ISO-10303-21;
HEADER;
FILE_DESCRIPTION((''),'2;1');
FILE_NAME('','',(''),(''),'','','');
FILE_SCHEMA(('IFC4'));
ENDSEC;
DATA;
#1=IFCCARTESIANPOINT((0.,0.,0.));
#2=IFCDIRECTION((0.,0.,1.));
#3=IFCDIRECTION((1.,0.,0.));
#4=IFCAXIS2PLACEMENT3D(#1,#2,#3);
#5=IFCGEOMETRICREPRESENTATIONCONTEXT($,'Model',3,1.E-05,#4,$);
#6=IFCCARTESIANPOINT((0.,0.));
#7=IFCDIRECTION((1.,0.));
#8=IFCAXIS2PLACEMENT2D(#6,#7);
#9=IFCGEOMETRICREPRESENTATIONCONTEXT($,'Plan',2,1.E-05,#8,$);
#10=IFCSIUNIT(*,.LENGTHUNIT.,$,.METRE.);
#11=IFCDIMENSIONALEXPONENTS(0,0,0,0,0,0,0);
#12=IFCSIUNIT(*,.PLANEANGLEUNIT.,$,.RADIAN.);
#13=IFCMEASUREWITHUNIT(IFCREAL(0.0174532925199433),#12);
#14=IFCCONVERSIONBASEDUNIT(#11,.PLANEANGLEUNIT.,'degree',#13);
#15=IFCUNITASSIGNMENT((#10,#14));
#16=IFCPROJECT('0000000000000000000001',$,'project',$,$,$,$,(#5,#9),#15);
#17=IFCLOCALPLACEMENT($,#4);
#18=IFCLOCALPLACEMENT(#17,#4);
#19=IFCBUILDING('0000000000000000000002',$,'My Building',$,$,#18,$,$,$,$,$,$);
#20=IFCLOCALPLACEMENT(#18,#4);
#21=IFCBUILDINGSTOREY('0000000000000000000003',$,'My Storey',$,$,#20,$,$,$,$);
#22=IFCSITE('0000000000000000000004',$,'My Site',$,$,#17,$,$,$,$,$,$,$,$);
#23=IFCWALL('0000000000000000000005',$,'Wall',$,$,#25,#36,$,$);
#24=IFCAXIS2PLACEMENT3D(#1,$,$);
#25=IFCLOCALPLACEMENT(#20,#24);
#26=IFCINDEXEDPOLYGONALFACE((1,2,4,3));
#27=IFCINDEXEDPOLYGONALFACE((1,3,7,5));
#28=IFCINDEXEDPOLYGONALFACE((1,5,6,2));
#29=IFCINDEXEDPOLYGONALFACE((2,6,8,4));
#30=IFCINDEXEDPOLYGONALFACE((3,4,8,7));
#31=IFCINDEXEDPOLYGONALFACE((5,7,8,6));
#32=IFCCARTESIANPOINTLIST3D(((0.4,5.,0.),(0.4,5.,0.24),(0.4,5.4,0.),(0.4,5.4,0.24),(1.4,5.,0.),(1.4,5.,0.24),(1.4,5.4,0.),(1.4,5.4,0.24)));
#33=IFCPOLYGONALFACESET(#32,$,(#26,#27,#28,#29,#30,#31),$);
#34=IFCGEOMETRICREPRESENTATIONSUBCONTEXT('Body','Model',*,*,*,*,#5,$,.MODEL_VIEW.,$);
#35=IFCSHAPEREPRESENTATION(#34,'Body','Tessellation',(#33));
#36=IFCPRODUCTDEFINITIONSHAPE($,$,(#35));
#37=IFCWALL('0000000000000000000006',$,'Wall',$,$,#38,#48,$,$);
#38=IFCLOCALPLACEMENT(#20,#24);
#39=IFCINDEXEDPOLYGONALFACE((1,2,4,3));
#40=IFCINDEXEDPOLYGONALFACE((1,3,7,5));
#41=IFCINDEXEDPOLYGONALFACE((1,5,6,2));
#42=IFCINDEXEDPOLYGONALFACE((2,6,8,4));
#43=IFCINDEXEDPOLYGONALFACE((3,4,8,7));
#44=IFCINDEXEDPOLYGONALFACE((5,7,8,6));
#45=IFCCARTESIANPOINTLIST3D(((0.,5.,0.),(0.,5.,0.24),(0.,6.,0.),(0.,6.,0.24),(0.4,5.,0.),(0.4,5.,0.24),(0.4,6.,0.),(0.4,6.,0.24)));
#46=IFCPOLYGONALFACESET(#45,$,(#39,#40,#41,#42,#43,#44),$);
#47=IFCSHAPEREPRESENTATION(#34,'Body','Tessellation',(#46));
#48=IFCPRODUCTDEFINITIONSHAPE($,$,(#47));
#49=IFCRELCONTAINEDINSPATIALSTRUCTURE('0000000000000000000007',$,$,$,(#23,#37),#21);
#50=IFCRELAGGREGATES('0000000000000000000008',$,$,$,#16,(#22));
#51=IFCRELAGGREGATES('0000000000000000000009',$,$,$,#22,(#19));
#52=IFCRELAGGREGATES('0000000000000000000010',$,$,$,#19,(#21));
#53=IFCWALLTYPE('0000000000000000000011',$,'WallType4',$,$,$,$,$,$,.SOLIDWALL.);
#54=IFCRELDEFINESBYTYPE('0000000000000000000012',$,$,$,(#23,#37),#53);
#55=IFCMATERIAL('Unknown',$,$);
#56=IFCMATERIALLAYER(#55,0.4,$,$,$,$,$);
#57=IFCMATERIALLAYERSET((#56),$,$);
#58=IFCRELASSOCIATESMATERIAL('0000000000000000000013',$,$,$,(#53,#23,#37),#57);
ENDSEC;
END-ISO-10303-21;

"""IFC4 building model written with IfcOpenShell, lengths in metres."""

from ifc_helpers import new_model, entity, si_unit, converted_unit, frame, origin_with_axes, origin_2d_with_axis, place, context, subcontext, project, spatial, indexed_curve, outline, extrude, material, layer, layer_set, layer_usage, type_object, element, save


model = new_model("IFC4")

# Units and contexts
model_context = context("Model", 3, precision=1e-05, world=origin_with_axes())
plan_context = context("Plan", 2, precision=1e-05, world=origin_2d_with_axis())
body_context = subcontext(model_context, "Body", "Model", "MODEL_VIEW")
ifc_project = project(units=[si_unit("LENGTHUNIT", "METRE"), converted_unit("PLANEANGLEUNIT", "degree", entity("IfcReal", 0.0174532925199433), si_unit("PLANEANGLEUNIT", "RADIAN"), dimensions=[0, 0, 0, 0, 0, 0, 0])], contexts=[model_context, plan_context])

# Site, building, storey
site_placement = place(None, origin_with_axes())
site = spatial("IfcSite", under=ifc_project, at=site_placement, Name="My Site")
building_placement = place(site_placement, origin_with_axes())
building = spatial("IfcBuilding", under=site, at=building_placement, Name="My Building")
storey_placement = place(building_placement, origin_with_axes())
storey = spatial("IfcBuildingStorey", under=building, at=storey_placement, Name="My Storey")

# Walls
ifc_material = material(Name="Unknown")
ifc_layer = layer(ifc_material, 0.4)
ifc_layer_set = layer_set([ifc_layer])
ifc_layer_usage_1 = layer_usage(ifc_layer_set, "AXIS2", "POSITIVE", 0.0)
wall_type = type_object("IfcWallType", Name="WallType4", PredefinedType="SOLIDWALL", material=ifc_layer_set)
wall_1_placement = place(storey_placement, frame((0.4, 5.0, 0.0), z_axis=(0.0, 0.0, 1.0), x_axis=(1.0, 0.0, 0.0)))
element("IfcWall", 1, at=wall_1_placement, inside=storey, type_object=wall_type, material=ifc_layer_usage_1, Name="Wall", context=body_context, shape_type="SweptSolid", body=[
    extrude(outline(indexed_curve([(0.0, 0.0), (0.0, 0.4), (1.0, 0.4), (1.0, 0.0), (0.0, 0.0)], self_intersect=False)), origin_with_axes(), (0.0, 0.0, 1.0), 0.24),
])
ifc_layer_usage_2 = layer_usage(ifc_layer_set, "AXIS2", "POSITIVE", 0.0)
wall_2_placement = place(storey_placement, frame((0.0, 6.0, 0.0), z_axis=(0.0, 0.0, 1.0), x_axis=(0.0, -1.0, 0.0)))
element("IfcWall", 2, at=wall_2_placement, inside=storey, type_object=wall_type, material=ifc_layer_usage_2, Name="Wall", context=body_context, shape_type="SweptSolid", body=[
    extrude(outline(indexed_curve([(0.0, 0.0), (0.0, 0.4), (1.0, 0.4), (1.0, 0.0), (0.0, 0.0)], self_intersect=False)), origin_with_axes(), (0.0, 0.0, 1.0), 0.24),
])

save(model, "model.ifc")
